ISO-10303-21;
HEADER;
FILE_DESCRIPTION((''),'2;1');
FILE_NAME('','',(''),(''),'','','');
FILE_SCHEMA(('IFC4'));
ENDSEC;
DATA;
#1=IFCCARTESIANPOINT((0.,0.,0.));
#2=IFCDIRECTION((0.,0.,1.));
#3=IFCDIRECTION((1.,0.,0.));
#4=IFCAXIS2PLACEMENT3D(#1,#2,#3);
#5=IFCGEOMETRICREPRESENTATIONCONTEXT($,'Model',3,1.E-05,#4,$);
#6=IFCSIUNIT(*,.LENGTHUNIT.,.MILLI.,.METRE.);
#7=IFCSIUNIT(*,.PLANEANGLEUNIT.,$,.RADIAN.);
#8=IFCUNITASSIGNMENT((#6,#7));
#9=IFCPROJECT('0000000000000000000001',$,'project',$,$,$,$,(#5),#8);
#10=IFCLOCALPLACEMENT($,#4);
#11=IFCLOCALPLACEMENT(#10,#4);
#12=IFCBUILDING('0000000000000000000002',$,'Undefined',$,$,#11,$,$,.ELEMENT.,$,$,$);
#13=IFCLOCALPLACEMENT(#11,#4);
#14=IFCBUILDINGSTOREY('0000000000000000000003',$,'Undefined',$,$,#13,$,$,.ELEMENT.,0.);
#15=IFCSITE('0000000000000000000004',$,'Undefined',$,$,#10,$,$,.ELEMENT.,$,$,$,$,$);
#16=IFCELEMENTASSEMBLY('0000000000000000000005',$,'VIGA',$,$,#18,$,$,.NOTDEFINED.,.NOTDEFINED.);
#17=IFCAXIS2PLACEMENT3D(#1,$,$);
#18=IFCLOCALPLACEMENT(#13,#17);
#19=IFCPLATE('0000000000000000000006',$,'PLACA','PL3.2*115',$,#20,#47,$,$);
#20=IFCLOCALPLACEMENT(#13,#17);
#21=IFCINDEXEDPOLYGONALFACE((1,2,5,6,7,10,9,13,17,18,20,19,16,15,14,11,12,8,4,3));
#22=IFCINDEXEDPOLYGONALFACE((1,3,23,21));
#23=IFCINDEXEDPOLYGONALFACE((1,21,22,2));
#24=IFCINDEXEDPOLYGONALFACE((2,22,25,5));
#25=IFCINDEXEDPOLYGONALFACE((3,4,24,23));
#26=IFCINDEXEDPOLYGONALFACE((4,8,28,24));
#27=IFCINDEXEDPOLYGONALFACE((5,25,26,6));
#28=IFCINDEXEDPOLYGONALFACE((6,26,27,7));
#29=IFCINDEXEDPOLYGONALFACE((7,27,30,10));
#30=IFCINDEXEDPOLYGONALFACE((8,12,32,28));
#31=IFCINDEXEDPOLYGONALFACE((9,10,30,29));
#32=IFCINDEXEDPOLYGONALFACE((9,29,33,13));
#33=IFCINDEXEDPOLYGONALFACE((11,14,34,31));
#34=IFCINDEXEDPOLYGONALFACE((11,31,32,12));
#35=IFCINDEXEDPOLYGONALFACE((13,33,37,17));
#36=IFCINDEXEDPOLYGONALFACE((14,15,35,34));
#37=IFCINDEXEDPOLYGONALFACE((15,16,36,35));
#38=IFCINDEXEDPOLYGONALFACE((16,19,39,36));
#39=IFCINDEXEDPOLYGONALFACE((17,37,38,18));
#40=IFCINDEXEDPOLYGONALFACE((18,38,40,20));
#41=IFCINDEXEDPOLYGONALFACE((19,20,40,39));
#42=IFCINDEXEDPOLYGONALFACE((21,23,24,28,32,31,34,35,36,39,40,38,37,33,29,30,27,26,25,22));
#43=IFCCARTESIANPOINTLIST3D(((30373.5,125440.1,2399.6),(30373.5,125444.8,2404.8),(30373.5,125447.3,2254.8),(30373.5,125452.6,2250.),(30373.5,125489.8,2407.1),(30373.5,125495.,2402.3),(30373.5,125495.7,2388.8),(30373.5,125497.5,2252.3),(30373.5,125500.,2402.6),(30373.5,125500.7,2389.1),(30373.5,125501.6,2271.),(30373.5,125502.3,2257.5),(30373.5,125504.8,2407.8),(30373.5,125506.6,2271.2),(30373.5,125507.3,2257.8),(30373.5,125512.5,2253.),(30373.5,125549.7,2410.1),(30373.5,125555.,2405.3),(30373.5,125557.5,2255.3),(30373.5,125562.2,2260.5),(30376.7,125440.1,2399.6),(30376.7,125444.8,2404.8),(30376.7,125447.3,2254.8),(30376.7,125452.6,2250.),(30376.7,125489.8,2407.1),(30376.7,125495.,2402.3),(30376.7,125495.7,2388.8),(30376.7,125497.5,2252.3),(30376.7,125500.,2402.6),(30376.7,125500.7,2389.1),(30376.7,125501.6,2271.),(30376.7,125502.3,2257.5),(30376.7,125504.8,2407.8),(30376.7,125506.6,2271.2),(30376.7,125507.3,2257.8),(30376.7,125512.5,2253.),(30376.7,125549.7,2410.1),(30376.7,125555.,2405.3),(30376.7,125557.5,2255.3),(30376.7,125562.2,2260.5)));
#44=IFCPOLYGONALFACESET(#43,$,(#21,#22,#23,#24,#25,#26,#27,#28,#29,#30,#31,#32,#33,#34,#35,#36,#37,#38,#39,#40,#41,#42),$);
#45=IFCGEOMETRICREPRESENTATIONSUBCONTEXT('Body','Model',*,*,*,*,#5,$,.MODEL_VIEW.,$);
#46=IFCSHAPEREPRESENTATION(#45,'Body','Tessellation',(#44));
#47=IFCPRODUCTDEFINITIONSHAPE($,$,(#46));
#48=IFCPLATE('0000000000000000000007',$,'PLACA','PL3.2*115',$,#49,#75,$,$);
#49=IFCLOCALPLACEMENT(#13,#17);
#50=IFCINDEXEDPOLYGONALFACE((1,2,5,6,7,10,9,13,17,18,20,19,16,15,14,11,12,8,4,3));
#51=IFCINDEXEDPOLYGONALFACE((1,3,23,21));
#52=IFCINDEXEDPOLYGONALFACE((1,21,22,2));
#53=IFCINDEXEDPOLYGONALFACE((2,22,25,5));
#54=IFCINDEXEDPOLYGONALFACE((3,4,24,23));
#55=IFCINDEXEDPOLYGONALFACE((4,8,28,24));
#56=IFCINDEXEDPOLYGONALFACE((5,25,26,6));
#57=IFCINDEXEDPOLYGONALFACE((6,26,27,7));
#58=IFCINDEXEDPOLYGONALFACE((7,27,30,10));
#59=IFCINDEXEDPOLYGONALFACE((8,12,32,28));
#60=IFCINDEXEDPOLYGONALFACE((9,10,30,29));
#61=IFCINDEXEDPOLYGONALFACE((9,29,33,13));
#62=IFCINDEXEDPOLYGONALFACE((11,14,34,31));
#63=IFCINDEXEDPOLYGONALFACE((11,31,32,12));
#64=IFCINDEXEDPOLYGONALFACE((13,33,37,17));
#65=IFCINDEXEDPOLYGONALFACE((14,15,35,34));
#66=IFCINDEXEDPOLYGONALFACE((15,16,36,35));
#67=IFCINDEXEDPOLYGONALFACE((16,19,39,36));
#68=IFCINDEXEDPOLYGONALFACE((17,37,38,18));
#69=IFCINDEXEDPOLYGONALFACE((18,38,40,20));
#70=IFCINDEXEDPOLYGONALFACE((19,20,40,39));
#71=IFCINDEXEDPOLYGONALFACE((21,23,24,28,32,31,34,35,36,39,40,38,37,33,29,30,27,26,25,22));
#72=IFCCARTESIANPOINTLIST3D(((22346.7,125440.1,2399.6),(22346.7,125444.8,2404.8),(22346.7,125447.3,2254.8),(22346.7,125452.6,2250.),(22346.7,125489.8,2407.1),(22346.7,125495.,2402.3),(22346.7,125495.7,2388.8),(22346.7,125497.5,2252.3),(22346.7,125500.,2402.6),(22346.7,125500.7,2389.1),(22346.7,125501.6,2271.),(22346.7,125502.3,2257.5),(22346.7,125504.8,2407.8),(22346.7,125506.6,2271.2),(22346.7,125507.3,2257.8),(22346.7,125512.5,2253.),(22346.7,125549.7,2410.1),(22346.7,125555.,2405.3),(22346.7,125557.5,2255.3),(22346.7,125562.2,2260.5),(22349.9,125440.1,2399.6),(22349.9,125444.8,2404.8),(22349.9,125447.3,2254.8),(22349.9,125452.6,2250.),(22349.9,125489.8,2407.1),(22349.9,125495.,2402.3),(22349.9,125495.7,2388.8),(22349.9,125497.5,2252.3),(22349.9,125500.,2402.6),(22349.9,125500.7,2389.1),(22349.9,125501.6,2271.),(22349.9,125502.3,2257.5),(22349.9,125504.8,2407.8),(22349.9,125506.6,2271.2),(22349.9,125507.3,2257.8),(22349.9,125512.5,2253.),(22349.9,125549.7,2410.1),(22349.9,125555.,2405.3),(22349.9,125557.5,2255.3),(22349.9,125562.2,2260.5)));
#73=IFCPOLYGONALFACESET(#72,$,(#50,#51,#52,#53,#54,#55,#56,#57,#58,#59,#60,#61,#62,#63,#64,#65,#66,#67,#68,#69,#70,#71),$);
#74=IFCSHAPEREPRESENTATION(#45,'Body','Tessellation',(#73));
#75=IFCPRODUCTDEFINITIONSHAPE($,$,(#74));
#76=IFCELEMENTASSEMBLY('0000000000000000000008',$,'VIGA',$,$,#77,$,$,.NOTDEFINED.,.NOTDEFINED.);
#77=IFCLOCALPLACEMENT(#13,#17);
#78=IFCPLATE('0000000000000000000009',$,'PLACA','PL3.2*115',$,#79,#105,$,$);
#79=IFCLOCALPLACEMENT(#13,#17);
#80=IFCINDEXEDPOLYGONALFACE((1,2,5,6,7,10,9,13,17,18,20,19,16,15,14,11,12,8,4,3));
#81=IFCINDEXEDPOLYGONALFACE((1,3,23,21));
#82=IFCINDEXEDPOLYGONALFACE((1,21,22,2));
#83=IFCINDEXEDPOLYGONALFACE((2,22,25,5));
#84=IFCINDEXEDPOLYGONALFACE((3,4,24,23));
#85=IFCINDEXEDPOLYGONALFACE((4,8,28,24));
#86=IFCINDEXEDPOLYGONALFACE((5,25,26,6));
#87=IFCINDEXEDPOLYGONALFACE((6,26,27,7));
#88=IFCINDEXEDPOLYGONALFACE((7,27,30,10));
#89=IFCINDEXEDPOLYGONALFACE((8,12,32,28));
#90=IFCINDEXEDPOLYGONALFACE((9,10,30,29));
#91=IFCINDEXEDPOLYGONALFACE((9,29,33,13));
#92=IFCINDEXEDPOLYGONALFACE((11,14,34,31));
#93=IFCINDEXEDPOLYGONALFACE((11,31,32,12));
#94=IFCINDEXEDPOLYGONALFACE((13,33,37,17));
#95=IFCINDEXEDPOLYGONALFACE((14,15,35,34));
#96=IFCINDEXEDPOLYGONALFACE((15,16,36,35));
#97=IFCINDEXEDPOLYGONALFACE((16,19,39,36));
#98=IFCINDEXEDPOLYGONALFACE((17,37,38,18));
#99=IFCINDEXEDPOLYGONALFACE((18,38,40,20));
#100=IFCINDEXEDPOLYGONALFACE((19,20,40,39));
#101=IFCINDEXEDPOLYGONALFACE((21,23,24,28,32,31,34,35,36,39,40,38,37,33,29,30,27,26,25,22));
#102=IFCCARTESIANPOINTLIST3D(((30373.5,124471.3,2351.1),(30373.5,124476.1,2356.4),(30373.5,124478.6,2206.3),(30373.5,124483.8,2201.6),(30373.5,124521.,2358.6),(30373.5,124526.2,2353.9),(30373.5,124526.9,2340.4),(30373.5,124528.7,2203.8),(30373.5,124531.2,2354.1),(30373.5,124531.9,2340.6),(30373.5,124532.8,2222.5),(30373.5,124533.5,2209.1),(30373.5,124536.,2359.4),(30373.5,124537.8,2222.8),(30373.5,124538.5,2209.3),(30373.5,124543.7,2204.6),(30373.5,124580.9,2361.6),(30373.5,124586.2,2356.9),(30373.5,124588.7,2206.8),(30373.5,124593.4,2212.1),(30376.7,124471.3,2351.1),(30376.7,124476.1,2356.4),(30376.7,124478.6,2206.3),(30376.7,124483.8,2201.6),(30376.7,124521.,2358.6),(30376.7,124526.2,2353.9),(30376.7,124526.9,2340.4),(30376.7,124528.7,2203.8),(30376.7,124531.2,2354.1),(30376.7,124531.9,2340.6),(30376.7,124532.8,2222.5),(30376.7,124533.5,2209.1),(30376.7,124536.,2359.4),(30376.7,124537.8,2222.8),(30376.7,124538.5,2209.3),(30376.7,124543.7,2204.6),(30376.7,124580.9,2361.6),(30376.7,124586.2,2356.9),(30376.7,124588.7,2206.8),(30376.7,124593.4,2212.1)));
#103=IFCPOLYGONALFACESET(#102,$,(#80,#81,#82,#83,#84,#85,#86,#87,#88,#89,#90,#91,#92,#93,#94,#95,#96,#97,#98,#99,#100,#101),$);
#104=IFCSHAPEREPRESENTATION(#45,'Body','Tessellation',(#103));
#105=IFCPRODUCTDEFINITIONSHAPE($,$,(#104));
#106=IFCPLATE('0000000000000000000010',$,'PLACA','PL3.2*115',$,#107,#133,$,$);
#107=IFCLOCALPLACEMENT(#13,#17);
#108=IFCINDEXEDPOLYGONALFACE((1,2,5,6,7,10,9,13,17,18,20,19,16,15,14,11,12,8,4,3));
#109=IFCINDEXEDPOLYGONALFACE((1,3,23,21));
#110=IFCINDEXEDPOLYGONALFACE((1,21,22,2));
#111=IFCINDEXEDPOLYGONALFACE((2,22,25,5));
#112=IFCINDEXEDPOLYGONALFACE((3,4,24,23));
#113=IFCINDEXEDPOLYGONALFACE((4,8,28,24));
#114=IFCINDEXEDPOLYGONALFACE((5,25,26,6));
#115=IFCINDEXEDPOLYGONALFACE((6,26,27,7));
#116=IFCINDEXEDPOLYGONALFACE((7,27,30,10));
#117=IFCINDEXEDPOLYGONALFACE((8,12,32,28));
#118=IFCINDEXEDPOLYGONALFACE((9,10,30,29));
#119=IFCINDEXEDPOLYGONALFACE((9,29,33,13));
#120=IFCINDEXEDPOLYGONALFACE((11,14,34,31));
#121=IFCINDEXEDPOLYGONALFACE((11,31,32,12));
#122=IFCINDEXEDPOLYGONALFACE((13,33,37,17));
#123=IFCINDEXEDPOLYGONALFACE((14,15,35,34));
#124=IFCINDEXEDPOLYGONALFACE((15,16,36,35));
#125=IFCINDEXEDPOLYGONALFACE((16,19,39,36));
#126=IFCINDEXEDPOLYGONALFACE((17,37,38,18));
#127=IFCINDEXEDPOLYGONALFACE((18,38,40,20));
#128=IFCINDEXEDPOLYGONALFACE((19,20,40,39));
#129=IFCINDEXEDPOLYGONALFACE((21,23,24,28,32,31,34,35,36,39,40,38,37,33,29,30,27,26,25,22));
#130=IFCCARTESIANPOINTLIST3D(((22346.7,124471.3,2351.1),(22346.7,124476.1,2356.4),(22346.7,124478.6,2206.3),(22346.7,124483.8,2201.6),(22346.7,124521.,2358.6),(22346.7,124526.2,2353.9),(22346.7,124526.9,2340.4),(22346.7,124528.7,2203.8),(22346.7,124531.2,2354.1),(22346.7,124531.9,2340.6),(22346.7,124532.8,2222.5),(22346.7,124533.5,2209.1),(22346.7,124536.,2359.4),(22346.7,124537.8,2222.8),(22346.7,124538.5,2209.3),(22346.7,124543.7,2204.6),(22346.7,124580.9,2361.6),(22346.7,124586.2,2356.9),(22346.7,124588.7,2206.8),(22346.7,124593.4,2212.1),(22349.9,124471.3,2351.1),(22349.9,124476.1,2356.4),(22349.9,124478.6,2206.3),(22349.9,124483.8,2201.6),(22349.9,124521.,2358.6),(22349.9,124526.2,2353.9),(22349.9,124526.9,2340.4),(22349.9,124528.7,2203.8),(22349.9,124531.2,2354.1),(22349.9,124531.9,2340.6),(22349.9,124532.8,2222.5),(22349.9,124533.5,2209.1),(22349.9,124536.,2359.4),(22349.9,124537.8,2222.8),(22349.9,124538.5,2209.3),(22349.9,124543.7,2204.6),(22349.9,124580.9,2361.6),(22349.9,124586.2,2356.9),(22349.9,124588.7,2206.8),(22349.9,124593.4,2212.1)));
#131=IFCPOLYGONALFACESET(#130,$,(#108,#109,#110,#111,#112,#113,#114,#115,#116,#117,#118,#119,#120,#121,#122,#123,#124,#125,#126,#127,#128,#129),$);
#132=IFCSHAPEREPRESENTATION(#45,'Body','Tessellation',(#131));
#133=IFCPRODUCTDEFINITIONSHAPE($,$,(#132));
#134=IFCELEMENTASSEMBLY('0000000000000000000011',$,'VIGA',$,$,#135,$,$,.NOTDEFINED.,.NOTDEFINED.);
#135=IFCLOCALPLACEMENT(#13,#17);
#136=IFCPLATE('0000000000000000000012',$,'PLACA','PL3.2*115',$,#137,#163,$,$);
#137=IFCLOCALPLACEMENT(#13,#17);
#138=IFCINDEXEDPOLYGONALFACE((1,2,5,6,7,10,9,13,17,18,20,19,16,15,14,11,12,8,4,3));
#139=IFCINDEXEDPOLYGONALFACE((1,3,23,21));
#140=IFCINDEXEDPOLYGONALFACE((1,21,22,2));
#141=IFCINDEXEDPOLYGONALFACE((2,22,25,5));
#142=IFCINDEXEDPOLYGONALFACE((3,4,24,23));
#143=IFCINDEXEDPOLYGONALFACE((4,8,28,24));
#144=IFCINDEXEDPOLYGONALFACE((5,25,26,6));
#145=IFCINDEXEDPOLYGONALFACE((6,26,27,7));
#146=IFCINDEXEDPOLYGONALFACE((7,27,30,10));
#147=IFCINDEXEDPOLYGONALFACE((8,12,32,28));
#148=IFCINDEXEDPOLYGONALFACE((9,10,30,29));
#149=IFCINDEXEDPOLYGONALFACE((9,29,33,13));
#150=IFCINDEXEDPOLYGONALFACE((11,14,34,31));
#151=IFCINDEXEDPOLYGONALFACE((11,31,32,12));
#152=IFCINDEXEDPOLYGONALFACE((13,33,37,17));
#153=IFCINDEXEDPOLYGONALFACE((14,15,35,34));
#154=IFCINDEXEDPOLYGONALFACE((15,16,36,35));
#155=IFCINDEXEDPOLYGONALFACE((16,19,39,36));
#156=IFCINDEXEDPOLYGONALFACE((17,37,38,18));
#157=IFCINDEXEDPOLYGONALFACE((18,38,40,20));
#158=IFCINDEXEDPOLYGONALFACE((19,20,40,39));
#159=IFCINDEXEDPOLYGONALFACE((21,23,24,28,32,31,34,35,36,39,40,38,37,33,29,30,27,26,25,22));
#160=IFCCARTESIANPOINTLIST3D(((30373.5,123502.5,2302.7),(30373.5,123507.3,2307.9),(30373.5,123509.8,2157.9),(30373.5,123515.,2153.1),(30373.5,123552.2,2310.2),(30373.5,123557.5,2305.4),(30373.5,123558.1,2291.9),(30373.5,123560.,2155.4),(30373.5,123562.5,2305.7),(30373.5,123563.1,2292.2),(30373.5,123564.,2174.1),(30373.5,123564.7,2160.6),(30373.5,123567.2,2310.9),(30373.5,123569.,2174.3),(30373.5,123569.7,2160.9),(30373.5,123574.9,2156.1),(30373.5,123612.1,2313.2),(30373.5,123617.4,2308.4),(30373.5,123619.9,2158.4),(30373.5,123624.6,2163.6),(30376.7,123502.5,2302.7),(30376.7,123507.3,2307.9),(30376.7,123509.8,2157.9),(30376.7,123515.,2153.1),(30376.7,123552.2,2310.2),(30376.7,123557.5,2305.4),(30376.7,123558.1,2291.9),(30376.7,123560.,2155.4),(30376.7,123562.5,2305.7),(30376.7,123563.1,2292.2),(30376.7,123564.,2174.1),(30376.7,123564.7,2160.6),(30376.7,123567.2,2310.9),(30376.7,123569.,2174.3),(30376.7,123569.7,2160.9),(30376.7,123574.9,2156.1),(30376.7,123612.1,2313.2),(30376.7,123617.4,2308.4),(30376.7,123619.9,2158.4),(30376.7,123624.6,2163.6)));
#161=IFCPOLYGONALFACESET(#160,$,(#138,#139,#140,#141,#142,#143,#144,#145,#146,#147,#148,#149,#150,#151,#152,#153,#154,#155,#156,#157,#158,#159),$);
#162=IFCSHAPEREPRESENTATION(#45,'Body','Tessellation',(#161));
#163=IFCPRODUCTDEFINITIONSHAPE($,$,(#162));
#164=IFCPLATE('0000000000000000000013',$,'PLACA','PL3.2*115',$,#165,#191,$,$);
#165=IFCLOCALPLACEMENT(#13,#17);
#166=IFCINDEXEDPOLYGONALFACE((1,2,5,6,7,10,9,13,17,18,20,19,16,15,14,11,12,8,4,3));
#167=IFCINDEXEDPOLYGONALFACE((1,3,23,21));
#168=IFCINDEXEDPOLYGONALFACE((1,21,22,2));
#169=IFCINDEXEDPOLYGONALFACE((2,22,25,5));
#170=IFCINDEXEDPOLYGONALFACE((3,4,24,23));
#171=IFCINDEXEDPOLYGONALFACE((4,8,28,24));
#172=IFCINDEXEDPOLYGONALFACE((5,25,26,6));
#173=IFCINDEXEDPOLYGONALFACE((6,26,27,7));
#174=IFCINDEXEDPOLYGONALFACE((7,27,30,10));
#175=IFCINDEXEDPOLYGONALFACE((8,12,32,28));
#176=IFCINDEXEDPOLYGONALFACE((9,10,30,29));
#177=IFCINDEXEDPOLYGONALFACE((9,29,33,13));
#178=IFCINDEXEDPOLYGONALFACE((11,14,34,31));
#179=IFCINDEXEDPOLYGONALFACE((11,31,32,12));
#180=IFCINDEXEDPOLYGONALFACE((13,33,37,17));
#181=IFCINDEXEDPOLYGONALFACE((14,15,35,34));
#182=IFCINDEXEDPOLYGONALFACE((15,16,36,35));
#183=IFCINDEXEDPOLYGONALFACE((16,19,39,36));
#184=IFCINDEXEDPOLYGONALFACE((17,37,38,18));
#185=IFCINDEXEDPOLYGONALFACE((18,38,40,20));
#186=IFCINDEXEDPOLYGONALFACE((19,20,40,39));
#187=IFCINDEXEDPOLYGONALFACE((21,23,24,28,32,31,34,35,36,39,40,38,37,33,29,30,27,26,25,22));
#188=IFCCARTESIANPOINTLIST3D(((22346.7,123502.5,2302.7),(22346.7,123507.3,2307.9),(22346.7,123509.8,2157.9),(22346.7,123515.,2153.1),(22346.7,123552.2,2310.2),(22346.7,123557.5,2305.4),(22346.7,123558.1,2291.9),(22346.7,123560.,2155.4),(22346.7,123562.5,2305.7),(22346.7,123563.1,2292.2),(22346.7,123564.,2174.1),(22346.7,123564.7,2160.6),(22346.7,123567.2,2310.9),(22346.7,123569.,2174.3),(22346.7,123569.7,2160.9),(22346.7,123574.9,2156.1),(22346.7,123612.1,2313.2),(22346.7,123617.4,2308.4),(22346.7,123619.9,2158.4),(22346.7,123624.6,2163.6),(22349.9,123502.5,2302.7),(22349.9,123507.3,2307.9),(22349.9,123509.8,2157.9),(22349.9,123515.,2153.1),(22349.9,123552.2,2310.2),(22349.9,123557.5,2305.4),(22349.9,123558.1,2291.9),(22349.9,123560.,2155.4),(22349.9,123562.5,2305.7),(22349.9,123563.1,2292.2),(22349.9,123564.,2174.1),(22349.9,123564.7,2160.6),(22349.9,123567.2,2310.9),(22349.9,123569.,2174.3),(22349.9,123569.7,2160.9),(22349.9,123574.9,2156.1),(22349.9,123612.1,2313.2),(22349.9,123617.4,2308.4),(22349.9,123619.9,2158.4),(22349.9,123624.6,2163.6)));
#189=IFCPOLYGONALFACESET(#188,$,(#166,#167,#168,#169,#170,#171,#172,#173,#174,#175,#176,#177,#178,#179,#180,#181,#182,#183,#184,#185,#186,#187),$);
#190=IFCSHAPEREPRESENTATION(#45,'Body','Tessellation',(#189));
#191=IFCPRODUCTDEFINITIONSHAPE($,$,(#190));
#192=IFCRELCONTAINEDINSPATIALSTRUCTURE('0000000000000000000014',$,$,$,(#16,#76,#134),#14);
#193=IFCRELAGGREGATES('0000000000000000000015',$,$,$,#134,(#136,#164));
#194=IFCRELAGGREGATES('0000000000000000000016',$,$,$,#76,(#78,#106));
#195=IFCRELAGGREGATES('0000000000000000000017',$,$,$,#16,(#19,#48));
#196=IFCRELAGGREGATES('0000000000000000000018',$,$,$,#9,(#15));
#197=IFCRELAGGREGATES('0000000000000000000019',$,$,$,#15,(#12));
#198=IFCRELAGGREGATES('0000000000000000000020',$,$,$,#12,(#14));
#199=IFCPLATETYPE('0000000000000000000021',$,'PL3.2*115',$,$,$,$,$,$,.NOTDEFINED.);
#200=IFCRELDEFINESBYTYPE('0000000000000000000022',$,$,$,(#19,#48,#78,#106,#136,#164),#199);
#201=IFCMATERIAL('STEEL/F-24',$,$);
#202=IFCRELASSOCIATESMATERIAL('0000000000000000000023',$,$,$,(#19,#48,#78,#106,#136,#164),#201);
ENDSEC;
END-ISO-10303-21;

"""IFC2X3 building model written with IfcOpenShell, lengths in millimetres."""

from ifc_helpers import new_model, si_unit, frame, origin_with_axes, place, context, subcontext, project, spatial, polyline, outline, extrude, material, type_object, element, aggregate, save


model = new_model("IFC2X3")

# Units and contexts
model_context = context("Model", 3, precision=1e-05, world=origin_with_axes())
body_context = subcontext(model_context, "Body", "Model", "MODEL_VIEW")
ifc_project = project(units=[si_unit("LENGTHUNIT", "METRE", prefix="MILLI"), si_unit("PLANEANGLEUNIT", "RADIAN")], contexts=[model_context])

# Site, building, storey
site_placement = place(None, origin_with_axes())
site = spatial("IfcSite", under=ifc_project, at=site_placement, Name="Undefined", CompositionType="ELEMENT")
building_placement = place(site_placement, origin_with_axes())
building = spatial("IfcBuilding", under=site, at=building_placement, Name="Undefined", CompositionType="ELEMENT")
storey_placement = place(building_placement, origin_with_axes())
storey = spatial("IfcBuildingStorey", under=building, at=storey_placement, Name="Undefined", CompositionType="ELEMENT", Elevation=0.0)

# Element assemblies, plates
assembly_1_placement = place(storey_placement, origin_with_axes())
assembly_1 = element("IfcElementAssembly", 1, at=assembly_1_placement, inside=storey, Name="VIGA", AssemblyPlace="NOTDEFINED", PredefinedType="NOTDEFINED")
ifc_material_1 = material(Name="STEEL/F-24")
plate_type_1 = type_object("IfcPlateType", Name="PL3.2*115", PredefinedType="NOTDEFINED")
plate_1_placement = place(assembly_1_placement, frame((30375.1, 125439.9, 2404.6), z_axis=(-1.0, 0.0, 0.0), x_axis=(0.0, 0.998752, 0.04995)))
plate_1 = element("IfcPlate", 2, at=plate_1_placement, type_object=plate_type_1, material=ifc_material_1, Name="PLACA", Description="PL3.2*115", context=body_context, shape_type="SweptSolid", body=[
    extrude(outline(polyline([(0.0, 5.0), (5.0, 0.0), (50.0, 0.0), (55.0, 5.0), (55.0, 18.5), (60.0, 18.5), (60.0, 5.0), (65.0, 0.0), (110.0, 0.0), (115.0, 5.0), (115.0, 150.0), (110.0, 155.0), (65.0, 155.0), (60.0, 150.0), (60.0, 136.5), (55.0, 136.5), (55.0, 150.0), (50.0, 155.0), (5.0, 155.0), (0.0, 150.0), (0.0, 5.0)])), frame((0.0, 0.0, -1.6), z_axis=(0.0, 0.0, 1.0), x_axis=(1.0, 0.0, 0.0)), (0.0, 0.0, 1.0), 3.2),
])
plate_2_placement = place(assembly_1_placement, frame((22348.3, 125439.9, 2404.6), z_axis=(-1.0, 0.0, 0.0), x_axis=(0.0, 0.998752, 0.04995)))
plate_2 = element("IfcPlate", 3, at=plate_2_placement, type_object=plate_type_1, material=ifc_material_1, Name="PLACA", Description="PL3.2*115", context=body_context, shape_type="SweptSolid", body=[
    extrude(outline(polyline([(0.0, 5.0), (5.0, 0.0), (50.0, 0.0), (55.0, 5.0), (55.0, 18.5), (60.0, 18.5), (60.0, 5.0), (65.0, 0.0), (110.0, 0.0), (115.0, 5.0), (115.0, 150.0), (110.0, 155.0), (65.0, 155.0), (60.0, 150.0), (60.0, 136.5), (55.0, 136.5), (55.0, 150.0), (50.0, 155.0), (5.0, 155.0), (0.0, 150.0), (0.0, 5.0)])), frame((0.0, 0.0, -1.6), z_axis=(0.0, 0.0, 1.0), x_axis=(1.0, 0.0, 0.0)), (0.0, 0.0, 1.0), 3.2),
])
assembly_2_placement = place(storey_placement, origin_with_axes())
assembly_2 = element("IfcElementAssembly", 4, at=assembly_2_placement, inside=storey, Name="VIGA", AssemblyPlace="NOTDEFINED", PredefinedType="NOTDEFINED")
plate_3_placement = place(assembly_2_placement, frame((30375.1, 124471.1, 2356.1), z_axis=(-1.0, 0.0, 0.0), x_axis=(0.0, 0.998752, 0.04995)))
plate_3 = element("IfcPlate", 5, at=plate_3_placement, type_object=plate_type_1, material=ifc_material_1, Name="PLACA", Description="PL3.2*115", context=body_context, shape_type="SweptSolid", body=[
    extrude(outline(polyline([(0.0, 5.0), (5.0, 0.0), (50.0, 0.0), (55.0, 5.0), (55.0, 18.5), (60.0, 18.5), (60.0, 5.0), (65.0, 0.0), (110.0, 0.0), (115.0, 5.0), (115.0, 150.0), (110.0, 155.0), (65.0, 155.0), (60.0, 150.0), (60.0, 136.5), (55.0, 136.5), (55.0, 150.0), (50.0, 155.0), (5.0, 155.0), (0.0, 150.0), (0.0, 5.0)])), frame((0.0, 0.0, -1.6), z_axis=(0.0, 0.0, 1.0), x_axis=(1.0, 0.0, 0.0)), (0.0, 0.0, 1.0), 3.2),
])
plate_4_placement = place(assembly_2_placement, frame((22348.3, 124471.1, 2356.1), z_axis=(-1.0, 0.0, 0.0), x_axis=(0.0, 0.998752, 0.04995)))
plate_4 = element("IfcPlate", 6, at=plate_4_placement, type_object=plate_type_1, material=ifc_material_1, Name="PLACA", Description="PL3.2*115", context=body_context, shape_type="SweptSolid", body=[
    extrude(outline(polyline([(0.0, 5.0), (5.0, 0.0), (50.0, 0.0), (55.0, 5.0), (55.0, 18.5), (60.0, 18.5), (60.0, 5.0), (65.0, 0.0), (110.0, 0.0), (115.0, 5.0), (115.0, 150.0), (110.0, 155.0), (65.0, 155.0), (60.0, 150.0), (60.0, 136.5), (55.0, 136.5), (55.0, 150.0), (50.0, 155.0), (5.0, 155.0), (0.0, 150.0), (0.0, 5.0)])), frame((0.0, 0.0, -1.6), z_axis=(0.0, 0.0, 1.0), x_axis=(1.0, 0.0, 0.0)), (0.0, 0.0, 1.0), 3.2),
])
assembly_3_placement = place(storey_placement, origin_with_axes())
assembly_3 = element("IfcElementAssembly", 7, at=assembly_3_placement, inside=storey, Name="VIGA", AssemblyPlace="NOTDEFINED", PredefinedType="NOTDEFINED")
plate_5_placement = place(assembly_3_placement, frame((30375.1, 123502.3, 2307.7), z_axis=(-1.0, 0.0, 0.0), x_axis=(0.0, 0.998752, 0.04995)))
plate_5 = element("IfcPlate", 8, at=plate_5_placement, type_object=plate_type_1, material=ifc_material_1, Name="PLACA", Description="PL3.2*115", context=body_context, shape_type="SweptSolid", body=[
    extrude(outline(polyline([(0.0, 5.0), (5.0, 0.0), (50.0, 0.0), (55.0, 5.0), (55.0, 18.5), (60.0, 18.5), (60.0, 5.0), (65.0, 0.0), (110.0, 0.0), (115.0, 5.0), (115.0, 150.0), (110.0, 155.0), (65.0, 155.0), (60.0, 150.0), (60.0, 136.5), (55.0, 136.5), (55.0, 150.0), (50.0, 155.0), (5.0, 155.0), (0.0, 150.0), (0.0, 5.0)])), frame((0.0, 0.0, -1.6), z_axis=(0.0, 0.0, 1.0), x_axis=(1.0, 0.0, 0.0)), (0.0, 0.0, 1.0), 3.2),
])
plate_6_placement = place(assembly_3_placement, frame((22348.3, 123502.3, 2307.7), z_axis=(-1.0, 0.0, 0.0), x_axis=(0.0, 0.998752, 0.04995)))
plate_6 = element("IfcPlate", 9, at=plate_6_placement, type_object=plate_type_1, material=ifc_material_1, Name="PLACA", Description="PL3.2*115", context=body_context, shape_type="SweptSolid", body=[
    extrude(outline(polyline([(0.0, 5.0), (5.0, 0.0), (50.0, 0.0), (55.0, 5.0), (55.0, 18.5), (60.0, 18.5), (60.0, 5.0), (65.0, 0.0), (110.0, 0.0), (115.0, 5.0), (115.0, 150.0), (110.0, 155.0), (65.0, 155.0), (60.0, 150.0), (60.0, 136.5), (55.0, 136.5), (55.0, 150.0), (50.0, 155.0), (5.0, 155.0), (0.0, 150.0), (0.0, 5.0)])), frame((0.0, 0.0, -1.6), z_axis=(0.0, 0.0, 1.0), x_axis=(1.0, 0.0, 0.0)), (0.0, 0.0, 1.0), 3.2),
])

aggregate(assembly_3, [plate_5, plate_6])
aggregate(assembly_2, [plate_3, plate_4])
aggregate(assembly_1, [plate_1, plate_2])

save(model, "model.ifc")
